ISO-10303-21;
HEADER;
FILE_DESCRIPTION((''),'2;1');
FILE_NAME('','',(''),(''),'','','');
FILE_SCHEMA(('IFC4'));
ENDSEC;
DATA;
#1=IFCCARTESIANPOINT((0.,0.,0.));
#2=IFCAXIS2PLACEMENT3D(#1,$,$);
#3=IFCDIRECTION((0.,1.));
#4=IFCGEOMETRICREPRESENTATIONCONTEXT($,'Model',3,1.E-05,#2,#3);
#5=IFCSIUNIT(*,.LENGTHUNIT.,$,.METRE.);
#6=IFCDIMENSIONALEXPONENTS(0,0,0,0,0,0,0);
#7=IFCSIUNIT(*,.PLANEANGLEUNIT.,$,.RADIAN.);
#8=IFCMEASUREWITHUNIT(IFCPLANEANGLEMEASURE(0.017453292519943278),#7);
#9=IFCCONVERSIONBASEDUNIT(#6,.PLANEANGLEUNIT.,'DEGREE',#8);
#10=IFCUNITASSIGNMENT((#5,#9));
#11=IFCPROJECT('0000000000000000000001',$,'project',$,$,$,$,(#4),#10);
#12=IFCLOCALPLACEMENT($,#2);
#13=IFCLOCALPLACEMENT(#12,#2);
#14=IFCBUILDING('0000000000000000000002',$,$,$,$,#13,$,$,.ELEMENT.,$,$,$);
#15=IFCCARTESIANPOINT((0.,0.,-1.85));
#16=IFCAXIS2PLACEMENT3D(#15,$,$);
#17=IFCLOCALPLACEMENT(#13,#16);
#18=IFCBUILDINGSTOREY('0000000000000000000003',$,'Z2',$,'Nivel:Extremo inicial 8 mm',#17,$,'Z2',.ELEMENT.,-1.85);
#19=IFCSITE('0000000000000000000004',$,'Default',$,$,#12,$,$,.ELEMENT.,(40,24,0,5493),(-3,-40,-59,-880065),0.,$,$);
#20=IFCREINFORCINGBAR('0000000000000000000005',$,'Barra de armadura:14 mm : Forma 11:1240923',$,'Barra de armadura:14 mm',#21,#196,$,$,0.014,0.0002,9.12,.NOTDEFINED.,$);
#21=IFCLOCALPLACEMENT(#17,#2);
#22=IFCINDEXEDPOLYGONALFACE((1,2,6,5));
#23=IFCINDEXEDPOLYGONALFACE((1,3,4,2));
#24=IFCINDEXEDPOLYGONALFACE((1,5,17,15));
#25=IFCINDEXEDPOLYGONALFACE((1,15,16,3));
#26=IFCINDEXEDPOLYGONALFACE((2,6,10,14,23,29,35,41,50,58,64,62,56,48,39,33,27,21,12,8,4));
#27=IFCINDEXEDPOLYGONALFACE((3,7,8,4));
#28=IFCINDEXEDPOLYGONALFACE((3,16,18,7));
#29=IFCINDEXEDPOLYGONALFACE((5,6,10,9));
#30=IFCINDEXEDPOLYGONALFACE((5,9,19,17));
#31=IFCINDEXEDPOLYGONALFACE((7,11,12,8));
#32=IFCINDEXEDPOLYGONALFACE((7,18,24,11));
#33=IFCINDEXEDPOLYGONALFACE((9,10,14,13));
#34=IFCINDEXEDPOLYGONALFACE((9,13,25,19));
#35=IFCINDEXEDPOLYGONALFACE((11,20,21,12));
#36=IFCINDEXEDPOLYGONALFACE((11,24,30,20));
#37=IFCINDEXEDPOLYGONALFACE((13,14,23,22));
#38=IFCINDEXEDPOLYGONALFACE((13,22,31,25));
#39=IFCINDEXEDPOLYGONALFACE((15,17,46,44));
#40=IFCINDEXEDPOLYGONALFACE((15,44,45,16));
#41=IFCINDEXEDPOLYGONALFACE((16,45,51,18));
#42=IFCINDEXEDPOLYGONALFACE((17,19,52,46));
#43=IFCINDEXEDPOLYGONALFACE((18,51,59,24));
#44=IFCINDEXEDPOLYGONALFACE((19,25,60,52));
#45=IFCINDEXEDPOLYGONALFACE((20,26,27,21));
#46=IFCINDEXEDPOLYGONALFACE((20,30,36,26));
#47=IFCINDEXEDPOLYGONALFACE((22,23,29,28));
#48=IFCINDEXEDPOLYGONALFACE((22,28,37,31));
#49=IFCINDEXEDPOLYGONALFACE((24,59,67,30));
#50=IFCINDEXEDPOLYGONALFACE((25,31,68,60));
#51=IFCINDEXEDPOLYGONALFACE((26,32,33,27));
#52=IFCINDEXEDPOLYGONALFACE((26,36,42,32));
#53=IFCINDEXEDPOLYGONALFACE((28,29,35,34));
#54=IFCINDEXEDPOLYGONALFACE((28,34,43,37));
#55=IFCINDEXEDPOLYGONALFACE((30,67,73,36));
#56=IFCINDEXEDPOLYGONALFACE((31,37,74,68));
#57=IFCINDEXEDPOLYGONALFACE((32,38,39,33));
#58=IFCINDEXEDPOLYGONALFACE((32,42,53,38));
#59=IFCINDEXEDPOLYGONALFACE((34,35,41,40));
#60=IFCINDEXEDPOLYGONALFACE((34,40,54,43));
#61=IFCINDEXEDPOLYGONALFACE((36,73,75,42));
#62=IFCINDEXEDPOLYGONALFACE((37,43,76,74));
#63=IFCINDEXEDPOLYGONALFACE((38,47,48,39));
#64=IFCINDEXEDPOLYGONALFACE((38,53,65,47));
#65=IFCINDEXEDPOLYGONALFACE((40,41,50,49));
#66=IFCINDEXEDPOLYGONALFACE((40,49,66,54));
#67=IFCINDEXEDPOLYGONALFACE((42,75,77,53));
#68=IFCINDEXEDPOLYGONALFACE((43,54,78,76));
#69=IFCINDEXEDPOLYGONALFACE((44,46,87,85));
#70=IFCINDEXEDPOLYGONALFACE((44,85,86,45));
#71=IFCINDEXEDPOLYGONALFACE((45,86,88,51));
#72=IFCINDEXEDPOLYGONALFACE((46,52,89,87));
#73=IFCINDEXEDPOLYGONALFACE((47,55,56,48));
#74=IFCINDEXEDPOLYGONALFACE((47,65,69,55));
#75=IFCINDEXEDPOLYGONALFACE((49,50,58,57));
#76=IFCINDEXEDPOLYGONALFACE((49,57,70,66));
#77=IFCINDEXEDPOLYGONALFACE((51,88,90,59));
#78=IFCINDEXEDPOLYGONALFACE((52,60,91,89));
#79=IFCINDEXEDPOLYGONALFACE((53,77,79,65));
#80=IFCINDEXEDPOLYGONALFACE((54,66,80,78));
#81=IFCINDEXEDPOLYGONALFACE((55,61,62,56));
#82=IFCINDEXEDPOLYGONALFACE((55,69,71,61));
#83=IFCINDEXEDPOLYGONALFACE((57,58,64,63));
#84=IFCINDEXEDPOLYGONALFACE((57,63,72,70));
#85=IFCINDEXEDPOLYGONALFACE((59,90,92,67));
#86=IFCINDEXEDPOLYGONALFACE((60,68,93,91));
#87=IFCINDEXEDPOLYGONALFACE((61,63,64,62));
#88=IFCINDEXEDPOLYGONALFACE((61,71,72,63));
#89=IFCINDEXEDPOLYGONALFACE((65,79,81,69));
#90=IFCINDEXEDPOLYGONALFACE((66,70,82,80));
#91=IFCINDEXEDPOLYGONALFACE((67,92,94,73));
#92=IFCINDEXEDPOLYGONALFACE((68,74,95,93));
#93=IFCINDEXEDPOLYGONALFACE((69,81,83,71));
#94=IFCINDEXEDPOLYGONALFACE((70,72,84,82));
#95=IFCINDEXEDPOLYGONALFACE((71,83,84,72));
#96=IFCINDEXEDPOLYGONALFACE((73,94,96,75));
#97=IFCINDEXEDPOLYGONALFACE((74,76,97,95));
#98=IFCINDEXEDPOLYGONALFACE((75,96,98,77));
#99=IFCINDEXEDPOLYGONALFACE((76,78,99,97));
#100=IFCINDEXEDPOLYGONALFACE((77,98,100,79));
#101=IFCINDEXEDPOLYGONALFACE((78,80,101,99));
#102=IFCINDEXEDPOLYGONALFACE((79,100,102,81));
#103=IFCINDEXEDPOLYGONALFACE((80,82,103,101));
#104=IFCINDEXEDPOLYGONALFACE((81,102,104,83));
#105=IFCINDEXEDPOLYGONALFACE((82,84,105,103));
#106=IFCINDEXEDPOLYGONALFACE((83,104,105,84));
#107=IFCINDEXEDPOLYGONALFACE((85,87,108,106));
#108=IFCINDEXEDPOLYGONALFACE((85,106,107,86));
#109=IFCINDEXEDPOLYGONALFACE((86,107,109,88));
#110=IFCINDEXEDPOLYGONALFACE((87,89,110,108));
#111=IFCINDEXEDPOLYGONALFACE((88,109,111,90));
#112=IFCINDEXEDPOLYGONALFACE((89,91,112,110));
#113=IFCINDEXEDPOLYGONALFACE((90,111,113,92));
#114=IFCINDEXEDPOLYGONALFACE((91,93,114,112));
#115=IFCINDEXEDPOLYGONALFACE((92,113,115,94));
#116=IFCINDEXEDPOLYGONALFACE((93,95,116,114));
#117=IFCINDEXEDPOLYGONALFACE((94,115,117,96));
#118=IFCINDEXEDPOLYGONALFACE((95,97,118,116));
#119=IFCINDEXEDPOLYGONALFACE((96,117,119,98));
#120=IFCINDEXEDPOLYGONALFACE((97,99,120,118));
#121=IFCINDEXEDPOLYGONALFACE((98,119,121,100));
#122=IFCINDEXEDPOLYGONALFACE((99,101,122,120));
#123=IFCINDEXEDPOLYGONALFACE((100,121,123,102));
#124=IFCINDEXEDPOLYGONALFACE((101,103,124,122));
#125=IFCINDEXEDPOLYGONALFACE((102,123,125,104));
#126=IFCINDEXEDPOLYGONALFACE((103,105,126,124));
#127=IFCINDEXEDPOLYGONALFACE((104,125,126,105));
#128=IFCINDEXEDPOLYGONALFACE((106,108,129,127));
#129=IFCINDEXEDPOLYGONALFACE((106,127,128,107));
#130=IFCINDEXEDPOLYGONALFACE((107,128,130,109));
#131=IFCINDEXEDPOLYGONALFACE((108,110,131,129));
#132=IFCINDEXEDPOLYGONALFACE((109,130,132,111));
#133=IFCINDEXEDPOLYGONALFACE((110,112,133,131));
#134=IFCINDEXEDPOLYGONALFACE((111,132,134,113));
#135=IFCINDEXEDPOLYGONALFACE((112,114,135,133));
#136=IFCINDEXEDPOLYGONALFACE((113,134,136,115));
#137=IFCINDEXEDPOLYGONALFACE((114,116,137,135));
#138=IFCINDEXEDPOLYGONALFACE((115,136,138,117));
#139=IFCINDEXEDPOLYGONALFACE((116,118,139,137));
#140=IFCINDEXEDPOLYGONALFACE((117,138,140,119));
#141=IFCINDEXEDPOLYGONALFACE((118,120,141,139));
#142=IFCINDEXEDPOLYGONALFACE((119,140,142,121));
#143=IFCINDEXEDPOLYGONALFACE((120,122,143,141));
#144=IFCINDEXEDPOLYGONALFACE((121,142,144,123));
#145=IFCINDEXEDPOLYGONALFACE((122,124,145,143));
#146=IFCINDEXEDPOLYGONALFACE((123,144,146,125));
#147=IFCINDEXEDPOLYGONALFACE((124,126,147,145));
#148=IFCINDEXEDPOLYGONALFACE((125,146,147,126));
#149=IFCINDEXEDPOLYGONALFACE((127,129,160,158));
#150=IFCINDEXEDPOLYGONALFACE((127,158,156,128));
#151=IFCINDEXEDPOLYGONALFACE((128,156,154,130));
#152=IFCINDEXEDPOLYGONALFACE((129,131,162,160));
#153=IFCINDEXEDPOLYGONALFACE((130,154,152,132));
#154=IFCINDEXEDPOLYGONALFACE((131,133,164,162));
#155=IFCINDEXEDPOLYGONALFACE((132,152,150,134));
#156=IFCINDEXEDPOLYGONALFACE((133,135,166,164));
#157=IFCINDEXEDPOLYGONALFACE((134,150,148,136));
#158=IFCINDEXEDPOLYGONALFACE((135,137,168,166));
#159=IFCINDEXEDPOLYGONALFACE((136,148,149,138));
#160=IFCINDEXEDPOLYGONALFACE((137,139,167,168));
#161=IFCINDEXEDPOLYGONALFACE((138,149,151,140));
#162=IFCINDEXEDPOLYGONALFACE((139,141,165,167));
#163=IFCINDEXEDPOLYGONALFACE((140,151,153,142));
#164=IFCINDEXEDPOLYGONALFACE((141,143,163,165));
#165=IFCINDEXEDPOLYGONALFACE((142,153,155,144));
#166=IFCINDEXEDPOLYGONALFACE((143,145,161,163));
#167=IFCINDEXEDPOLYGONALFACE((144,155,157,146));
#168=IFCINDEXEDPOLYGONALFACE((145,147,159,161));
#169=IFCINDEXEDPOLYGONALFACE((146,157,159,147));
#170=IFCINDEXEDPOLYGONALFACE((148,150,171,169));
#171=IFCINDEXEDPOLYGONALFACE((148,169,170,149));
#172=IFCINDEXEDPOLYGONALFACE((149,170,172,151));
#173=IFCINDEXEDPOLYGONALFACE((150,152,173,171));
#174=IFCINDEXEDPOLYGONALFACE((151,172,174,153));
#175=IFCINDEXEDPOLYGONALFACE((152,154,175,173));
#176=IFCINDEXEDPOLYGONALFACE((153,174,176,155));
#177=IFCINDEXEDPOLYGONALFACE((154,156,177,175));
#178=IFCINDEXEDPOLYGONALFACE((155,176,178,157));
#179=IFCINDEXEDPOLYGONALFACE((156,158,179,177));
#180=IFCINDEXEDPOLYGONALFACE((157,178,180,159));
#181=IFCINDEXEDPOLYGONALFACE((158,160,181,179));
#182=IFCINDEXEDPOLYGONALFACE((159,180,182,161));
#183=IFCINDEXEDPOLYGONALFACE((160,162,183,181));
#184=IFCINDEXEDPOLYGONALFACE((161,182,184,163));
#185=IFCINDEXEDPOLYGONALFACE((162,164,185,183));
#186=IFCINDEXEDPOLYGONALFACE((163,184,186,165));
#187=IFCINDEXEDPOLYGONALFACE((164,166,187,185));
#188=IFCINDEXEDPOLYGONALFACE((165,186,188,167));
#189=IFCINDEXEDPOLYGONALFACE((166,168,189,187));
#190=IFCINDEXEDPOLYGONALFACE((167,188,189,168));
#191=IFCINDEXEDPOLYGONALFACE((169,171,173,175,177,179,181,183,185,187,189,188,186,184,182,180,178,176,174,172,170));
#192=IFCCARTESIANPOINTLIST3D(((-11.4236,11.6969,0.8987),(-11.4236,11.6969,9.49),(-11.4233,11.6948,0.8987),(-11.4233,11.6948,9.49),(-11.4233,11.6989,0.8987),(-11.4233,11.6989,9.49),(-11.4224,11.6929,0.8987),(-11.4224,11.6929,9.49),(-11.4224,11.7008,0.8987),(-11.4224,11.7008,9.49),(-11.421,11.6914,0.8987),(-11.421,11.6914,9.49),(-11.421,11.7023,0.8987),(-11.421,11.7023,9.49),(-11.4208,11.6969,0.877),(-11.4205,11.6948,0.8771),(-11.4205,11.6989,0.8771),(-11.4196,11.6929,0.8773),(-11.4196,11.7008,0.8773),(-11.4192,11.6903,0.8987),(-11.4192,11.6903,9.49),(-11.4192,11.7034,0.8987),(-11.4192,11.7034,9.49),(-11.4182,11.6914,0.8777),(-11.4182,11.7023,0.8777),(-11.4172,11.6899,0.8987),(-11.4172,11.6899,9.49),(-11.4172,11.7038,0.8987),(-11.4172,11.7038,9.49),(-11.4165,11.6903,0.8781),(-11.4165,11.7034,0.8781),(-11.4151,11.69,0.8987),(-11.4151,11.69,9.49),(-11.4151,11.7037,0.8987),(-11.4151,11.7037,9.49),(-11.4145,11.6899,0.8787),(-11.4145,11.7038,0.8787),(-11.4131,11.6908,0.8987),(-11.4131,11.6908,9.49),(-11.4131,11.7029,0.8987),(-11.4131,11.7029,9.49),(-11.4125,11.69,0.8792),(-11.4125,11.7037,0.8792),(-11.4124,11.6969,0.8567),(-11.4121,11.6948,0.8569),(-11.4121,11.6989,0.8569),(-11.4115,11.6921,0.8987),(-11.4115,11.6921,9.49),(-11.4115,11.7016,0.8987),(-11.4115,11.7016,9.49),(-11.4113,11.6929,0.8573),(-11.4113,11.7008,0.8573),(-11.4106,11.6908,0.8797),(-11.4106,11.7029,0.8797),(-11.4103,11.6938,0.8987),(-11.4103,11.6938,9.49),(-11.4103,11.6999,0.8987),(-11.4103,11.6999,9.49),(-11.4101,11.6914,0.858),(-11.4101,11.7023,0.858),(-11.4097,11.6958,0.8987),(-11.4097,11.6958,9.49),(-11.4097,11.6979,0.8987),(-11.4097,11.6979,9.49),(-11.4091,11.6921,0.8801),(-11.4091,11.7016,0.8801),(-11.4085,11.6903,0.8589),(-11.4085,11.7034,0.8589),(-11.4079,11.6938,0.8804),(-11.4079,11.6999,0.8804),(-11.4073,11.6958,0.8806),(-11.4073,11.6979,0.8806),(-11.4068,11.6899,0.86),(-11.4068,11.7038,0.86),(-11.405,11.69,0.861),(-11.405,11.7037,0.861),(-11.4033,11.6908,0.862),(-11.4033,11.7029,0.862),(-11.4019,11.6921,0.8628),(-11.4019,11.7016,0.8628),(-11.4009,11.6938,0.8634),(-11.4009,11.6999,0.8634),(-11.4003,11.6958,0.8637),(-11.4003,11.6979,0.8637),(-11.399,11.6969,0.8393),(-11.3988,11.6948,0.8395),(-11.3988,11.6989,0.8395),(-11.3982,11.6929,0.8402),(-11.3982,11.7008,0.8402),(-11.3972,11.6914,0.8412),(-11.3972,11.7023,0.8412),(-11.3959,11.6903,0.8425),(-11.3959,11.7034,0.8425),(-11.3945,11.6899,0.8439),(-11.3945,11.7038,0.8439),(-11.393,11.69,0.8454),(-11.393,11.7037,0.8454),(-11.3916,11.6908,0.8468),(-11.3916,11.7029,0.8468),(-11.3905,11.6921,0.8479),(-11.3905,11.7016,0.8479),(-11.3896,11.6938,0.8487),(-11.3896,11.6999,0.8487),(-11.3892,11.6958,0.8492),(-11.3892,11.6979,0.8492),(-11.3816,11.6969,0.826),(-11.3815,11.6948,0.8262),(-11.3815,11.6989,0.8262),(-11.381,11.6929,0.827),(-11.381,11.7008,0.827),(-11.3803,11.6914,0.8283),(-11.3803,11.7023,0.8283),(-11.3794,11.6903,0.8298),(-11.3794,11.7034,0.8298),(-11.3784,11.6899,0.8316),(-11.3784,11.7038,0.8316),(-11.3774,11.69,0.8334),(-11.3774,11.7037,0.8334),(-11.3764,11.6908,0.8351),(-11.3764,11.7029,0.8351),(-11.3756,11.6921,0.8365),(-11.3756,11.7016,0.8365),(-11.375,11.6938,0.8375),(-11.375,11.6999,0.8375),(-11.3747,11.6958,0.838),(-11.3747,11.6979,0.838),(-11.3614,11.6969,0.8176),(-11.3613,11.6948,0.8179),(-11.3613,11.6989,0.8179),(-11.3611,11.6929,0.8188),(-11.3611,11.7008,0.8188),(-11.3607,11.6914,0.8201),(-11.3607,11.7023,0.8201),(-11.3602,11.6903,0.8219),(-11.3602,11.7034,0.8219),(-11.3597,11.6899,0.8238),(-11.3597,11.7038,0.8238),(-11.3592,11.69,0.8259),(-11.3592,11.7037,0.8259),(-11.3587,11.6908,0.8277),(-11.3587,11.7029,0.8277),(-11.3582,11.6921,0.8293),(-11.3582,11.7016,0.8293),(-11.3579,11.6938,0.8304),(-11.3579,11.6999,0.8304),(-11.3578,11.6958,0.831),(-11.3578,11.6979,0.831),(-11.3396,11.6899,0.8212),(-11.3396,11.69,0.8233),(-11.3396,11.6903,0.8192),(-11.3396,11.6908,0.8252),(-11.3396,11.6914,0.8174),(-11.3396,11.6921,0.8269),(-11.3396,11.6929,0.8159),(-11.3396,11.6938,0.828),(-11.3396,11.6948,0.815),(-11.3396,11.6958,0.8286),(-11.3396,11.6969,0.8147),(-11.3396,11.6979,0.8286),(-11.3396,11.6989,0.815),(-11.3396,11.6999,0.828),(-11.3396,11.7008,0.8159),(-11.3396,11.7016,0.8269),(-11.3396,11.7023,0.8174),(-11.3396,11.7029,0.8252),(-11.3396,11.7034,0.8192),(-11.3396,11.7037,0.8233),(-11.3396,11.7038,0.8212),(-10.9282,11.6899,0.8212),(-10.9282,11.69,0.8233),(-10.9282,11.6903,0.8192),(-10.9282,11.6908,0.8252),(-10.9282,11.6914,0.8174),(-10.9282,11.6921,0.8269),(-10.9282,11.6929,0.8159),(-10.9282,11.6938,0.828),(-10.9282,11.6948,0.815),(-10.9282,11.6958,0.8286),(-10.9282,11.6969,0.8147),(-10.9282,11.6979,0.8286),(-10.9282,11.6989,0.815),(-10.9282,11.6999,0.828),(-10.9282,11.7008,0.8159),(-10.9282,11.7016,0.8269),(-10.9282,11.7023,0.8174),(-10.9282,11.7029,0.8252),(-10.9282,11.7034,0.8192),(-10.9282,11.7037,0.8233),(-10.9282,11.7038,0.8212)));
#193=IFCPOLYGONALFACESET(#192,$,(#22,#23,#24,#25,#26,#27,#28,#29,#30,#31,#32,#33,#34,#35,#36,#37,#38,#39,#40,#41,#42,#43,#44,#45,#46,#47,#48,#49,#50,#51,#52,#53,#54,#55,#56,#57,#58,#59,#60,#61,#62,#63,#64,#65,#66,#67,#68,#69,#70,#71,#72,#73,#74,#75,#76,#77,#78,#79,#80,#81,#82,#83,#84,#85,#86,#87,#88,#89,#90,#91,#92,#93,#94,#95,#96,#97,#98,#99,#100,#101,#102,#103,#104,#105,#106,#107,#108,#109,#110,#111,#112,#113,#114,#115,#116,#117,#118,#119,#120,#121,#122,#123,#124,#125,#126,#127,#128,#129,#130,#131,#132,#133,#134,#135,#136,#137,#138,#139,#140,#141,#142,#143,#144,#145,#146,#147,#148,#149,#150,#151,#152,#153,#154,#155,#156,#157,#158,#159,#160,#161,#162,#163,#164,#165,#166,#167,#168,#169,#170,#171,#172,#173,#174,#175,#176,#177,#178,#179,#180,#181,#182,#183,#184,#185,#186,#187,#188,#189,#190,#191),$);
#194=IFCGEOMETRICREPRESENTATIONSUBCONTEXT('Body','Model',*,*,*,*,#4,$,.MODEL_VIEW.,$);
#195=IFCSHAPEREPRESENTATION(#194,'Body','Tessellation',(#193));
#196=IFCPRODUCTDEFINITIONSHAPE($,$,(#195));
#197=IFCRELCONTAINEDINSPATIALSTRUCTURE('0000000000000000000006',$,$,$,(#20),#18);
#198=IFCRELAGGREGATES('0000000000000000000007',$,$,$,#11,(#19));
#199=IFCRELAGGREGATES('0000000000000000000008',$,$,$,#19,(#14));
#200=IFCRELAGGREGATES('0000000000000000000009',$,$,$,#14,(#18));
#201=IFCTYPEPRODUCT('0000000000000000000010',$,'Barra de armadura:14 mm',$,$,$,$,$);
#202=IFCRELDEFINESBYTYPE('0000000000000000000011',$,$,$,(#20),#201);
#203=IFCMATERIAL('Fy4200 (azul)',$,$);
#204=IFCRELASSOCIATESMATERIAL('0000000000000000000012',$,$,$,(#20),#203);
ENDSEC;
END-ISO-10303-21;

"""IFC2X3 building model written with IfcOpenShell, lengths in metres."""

from ifc_helpers import new_model, entity, si_unit, converted_unit, direction, frame, origin, place, context, subcontext, project, spatial, material, type_object, element, save


model = new_model("IFC2X3")

# Units and contexts
model_context = context("Model", 3, precision=1e-05, world=origin(), true_north=direction((0.0, 1.0)))
body_context = subcontext(model_context, "Body", "Model", "MODEL_VIEW")
ifc_project = project(units=[si_unit("LENGTHUNIT", "METRE"), converted_unit("PLANEANGLEUNIT", "DEGREE", entity("IfcPlaneAngleMeasure", 0.017453292519943278), si_unit("PLANEANGLEUNIT", "RADIAN"), dimensions=[0, 0, 0, 0, 0, 0, 0])], contexts=[model_context])

# Site, building, storey
site_placement = place(None, origin())
site = spatial("IfcSite", under=ifc_project, at=site_placement, Name="Default", CompositionType="ELEMENT", RefLatitude=(40, 24, 0, 5493), RefLongitude=(-3, -40, -59, -880065), RefElevation=0.0)
building_placement = place(site_placement, origin())
building = spatial("IfcBuilding", under=site, at=building_placement, CompositionType="ELEMENT")
storey_placement = place(building_placement, frame((0.0, 0.0, -1.85)))
storey = spatial("IfcBuildingStorey", under=building, at=storey_placement, Name="Z2", ObjectType="Nivel:Extremo inicial 8 mm", LongName="Z2", CompositionType="ELEMENT", Elevation=-1.85)

# Reinforcing bar
ifc_material_1 = material(Name="Fy4200 (azul)")
type_product_1 = type_object("IfcTypeProduct", Name="Barra de armadura:14 mm")
reinforcing_bar_1_placement = place(storey_placement, origin())
element("IfcReinforcingBar", 1, at=reinforcing_bar_1_placement, inside=storey, type_object=type_product_1, material=ifc_material_1, Name="Barra de armadura:14 mm : Forma 11:1240923", ObjectType="Barra de armadura:14 mm", BarLength=9.12, BarRole="NOTDEFINED", CrossSectionArea=0.0002, NominalDiameter=0.014, context=body_context, shape_type="AdvancedSweptSolid", body=[
    entity("IfcSweptDiskSolid", entity("IfcCompositeCurve", [entity("IfcCompositeCurveSegment", "CONTINUOUS", True, entity("IfcPolyline", [entity("IfcCartesianPoint", [-11.4166, 11.6969, 9.49]), entity("IfcCartesianPoint", [-11.4166, 11.6969, 0.8987])])), entity("IfcCompositeCurveSegment", "CONTINUOUS", True, entity("IfcTrimmedCurve", entity("IfcCircle", entity("IfcAxis2Placement3D", entity("IfcCartesianPoint", [-11.3396, 11.6969, 0.8987]), entity("IfcDirection", [0.0, -1.0, 0.0]), entity("IfcDirection", [0.0, 0.0, -1.0])), 0.077), [entity("IfcParameterValue", 270.0)], [entity("IfcParameterValue", 360.0)], True, "PARAMETER")), entity("IfcCompositeCurveSegment", "CONTINUOUS", True, entity("IfcPolyline", [entity("IfcCartesianPoint", [-11.3396, 11.6969, 0.8217]), entity("IfcCartesianPoint", [-10.9282, 11.6969, 0.8217])]))], False), 0.007, None, 0.0, 92.0),
])

save(model, "model.ifc")
